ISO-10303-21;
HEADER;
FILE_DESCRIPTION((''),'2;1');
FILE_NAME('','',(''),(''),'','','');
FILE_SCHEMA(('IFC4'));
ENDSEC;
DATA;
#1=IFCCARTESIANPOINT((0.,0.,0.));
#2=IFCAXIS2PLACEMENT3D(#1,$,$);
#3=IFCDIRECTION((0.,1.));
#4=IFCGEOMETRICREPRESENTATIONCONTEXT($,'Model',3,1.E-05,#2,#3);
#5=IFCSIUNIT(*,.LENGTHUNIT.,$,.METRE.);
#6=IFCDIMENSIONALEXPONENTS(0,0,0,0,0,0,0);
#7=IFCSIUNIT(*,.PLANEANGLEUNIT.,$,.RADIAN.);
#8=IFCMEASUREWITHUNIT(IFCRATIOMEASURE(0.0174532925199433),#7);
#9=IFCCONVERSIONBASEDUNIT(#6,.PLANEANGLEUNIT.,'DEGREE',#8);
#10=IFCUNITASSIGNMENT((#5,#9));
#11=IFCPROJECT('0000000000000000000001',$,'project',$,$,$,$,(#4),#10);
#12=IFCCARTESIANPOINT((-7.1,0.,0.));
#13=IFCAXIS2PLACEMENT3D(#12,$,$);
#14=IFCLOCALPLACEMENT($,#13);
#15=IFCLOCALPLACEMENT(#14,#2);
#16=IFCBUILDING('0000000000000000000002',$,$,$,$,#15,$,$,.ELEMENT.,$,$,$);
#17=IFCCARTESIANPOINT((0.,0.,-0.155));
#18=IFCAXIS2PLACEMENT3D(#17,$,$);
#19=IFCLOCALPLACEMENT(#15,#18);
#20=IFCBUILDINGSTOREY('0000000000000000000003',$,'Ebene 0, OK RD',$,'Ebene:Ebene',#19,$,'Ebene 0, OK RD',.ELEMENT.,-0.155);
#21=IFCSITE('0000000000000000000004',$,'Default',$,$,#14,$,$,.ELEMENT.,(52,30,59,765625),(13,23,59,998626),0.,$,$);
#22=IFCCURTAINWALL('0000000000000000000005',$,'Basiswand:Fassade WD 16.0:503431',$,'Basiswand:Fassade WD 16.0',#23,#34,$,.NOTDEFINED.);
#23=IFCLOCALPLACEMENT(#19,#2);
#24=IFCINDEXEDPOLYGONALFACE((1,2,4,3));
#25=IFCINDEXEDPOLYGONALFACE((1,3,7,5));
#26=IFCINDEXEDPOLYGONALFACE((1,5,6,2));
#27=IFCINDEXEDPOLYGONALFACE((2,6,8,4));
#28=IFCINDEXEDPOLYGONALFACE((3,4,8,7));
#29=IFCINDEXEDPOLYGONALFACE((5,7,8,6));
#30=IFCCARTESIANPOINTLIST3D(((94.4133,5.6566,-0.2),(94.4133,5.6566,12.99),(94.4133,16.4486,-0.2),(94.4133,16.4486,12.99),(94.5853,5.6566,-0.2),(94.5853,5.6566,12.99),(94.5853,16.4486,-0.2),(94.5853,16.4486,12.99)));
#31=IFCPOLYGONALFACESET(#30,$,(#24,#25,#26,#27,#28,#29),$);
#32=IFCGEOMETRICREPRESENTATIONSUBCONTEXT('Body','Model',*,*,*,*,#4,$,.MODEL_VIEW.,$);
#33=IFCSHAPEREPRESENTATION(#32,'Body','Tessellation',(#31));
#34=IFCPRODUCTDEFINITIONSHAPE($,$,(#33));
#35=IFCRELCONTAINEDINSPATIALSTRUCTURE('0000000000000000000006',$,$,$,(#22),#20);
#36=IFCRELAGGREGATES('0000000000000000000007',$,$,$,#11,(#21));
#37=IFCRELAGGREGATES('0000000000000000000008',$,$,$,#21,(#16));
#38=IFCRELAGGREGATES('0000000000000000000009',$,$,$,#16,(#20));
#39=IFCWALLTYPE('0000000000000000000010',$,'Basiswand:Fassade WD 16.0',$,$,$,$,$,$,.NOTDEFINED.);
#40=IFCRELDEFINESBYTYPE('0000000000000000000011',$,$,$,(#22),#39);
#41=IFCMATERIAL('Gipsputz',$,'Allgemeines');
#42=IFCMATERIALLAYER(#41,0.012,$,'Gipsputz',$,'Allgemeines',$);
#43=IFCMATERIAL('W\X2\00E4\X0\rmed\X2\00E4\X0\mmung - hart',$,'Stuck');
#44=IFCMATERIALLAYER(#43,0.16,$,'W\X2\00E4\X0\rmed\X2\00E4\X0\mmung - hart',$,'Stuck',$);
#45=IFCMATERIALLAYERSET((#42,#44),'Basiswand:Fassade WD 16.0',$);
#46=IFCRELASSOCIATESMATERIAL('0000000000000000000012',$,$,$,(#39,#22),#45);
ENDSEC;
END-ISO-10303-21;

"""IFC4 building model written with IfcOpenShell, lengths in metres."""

from ifc_helpers import new_model, entity, si_unit, converted_unit, direction, frame, frame_2d, origin, place, context, subcontext, project, spatial, rectangle, extrude, material, layer, layer_set, layer_usage, type_object, element, save


model = new_model("IFC4")

# Units and contexts
model_context = context("Model", 3, precision=1e-05, world=origin(), true_north=direction((0.0, 1.0)))
body_context = subcontext(model_context, "Body", "Model", "MODEL_VIEW")
ifc_project = project(units=[si_unit("LENGTHUNIT", "METRE"), converted_unit("PLANEANGLEUNIT", "DEGREE", entity("IfcRatioMeasure", 0.0174532925199433), si_unit("PLANEANGLEUNIT", "RADIAN"), dimensions=[0, 0, 0, 0, 0, 0, 0])], contexts=[model_context])

# Site, building, storey
site_placement = place(None, frame((-7.1, 0.0, 0.0)))
site = spatial("IfcSite", under=ifc_project, at=site_placement, Name="Default", CompositionType="ELEMENT", RefLatitude=(52, 30, 59, 765625), RefLongitude=(13, 23, 59, 998626), RefElevation=0.0)
building_placement = place(site_placement, origin())
building = spatial("IfcBuilding", under=site, at=building_placement, CompositionType="ELEMENT")
storey_placement = place(building_placement, frame((0.0, 0.0, -0.155)))
storey = spatial("IfcBuildingStorey", under=building, at=storey_placement, Name="Ebene 0, OK RD", ObjectType="Ebene:Ebene", LongName="Ebene 0, OK RD", CompositionType="ELEMENT", Elevation=-0.155)

# Curtain wall
ifc_material_1 = material(Name="Gipsputz", Category="Allgemeines")
ifc_layer_1 = layer(ifc_material_1, 0.012, Name="Gipsputz", Category="Allgemeines")
ifc_material_2 = material(Name="Wärmedämmung - hart", Category="Stuck")
ifc_layer_2 = layer(ifc_material_2, 0.16, Name="Wärmedämmung - hart", Category="Stuck")
ifc_layer_set = layer_set([ifc_layer_1, ifc_layer_2], Name="Basiswand:Fassade WD 16.0")
ifc_layer_usage = layer_usage(ifc_layer_set, "AXIS2", "POSITIVE", -0.086)
wall_type = type_object("IfcWallType", Name="Basiswand:Fassade WD 16.0", PredefinedType="NOTDEFINED", material=ifc_layer_set)
curtain_wall_placement = place(storey_placement, frame((94.4993, 16.4486, -0.2), z_axis=(0.0, 0.0, 1.0), x_axis=(0.0, -1.0, 0.0)))
element("IfcCurtainWall", 1, at=curtain_wall_placement, inside=storey, type_object=wall_type, material=ifc_layer_usage, Name="Basiswand:Fassade WD 16.0:503431", ObjectType="Basiswand:Fassade WD 16.0", PredefinedType="NOTDEFINED", context=body_context, shape_type="SweptSolid", body=[
    extrude(rectangle(XDim=10.792, YDim=0.172, at=frame_2d((5.396, 0.0), x_axis=(-1.0, 0.0))), origin(), (0.0, 0.0, 1.0), 13.19),
])

save(model, "model.ifc")
